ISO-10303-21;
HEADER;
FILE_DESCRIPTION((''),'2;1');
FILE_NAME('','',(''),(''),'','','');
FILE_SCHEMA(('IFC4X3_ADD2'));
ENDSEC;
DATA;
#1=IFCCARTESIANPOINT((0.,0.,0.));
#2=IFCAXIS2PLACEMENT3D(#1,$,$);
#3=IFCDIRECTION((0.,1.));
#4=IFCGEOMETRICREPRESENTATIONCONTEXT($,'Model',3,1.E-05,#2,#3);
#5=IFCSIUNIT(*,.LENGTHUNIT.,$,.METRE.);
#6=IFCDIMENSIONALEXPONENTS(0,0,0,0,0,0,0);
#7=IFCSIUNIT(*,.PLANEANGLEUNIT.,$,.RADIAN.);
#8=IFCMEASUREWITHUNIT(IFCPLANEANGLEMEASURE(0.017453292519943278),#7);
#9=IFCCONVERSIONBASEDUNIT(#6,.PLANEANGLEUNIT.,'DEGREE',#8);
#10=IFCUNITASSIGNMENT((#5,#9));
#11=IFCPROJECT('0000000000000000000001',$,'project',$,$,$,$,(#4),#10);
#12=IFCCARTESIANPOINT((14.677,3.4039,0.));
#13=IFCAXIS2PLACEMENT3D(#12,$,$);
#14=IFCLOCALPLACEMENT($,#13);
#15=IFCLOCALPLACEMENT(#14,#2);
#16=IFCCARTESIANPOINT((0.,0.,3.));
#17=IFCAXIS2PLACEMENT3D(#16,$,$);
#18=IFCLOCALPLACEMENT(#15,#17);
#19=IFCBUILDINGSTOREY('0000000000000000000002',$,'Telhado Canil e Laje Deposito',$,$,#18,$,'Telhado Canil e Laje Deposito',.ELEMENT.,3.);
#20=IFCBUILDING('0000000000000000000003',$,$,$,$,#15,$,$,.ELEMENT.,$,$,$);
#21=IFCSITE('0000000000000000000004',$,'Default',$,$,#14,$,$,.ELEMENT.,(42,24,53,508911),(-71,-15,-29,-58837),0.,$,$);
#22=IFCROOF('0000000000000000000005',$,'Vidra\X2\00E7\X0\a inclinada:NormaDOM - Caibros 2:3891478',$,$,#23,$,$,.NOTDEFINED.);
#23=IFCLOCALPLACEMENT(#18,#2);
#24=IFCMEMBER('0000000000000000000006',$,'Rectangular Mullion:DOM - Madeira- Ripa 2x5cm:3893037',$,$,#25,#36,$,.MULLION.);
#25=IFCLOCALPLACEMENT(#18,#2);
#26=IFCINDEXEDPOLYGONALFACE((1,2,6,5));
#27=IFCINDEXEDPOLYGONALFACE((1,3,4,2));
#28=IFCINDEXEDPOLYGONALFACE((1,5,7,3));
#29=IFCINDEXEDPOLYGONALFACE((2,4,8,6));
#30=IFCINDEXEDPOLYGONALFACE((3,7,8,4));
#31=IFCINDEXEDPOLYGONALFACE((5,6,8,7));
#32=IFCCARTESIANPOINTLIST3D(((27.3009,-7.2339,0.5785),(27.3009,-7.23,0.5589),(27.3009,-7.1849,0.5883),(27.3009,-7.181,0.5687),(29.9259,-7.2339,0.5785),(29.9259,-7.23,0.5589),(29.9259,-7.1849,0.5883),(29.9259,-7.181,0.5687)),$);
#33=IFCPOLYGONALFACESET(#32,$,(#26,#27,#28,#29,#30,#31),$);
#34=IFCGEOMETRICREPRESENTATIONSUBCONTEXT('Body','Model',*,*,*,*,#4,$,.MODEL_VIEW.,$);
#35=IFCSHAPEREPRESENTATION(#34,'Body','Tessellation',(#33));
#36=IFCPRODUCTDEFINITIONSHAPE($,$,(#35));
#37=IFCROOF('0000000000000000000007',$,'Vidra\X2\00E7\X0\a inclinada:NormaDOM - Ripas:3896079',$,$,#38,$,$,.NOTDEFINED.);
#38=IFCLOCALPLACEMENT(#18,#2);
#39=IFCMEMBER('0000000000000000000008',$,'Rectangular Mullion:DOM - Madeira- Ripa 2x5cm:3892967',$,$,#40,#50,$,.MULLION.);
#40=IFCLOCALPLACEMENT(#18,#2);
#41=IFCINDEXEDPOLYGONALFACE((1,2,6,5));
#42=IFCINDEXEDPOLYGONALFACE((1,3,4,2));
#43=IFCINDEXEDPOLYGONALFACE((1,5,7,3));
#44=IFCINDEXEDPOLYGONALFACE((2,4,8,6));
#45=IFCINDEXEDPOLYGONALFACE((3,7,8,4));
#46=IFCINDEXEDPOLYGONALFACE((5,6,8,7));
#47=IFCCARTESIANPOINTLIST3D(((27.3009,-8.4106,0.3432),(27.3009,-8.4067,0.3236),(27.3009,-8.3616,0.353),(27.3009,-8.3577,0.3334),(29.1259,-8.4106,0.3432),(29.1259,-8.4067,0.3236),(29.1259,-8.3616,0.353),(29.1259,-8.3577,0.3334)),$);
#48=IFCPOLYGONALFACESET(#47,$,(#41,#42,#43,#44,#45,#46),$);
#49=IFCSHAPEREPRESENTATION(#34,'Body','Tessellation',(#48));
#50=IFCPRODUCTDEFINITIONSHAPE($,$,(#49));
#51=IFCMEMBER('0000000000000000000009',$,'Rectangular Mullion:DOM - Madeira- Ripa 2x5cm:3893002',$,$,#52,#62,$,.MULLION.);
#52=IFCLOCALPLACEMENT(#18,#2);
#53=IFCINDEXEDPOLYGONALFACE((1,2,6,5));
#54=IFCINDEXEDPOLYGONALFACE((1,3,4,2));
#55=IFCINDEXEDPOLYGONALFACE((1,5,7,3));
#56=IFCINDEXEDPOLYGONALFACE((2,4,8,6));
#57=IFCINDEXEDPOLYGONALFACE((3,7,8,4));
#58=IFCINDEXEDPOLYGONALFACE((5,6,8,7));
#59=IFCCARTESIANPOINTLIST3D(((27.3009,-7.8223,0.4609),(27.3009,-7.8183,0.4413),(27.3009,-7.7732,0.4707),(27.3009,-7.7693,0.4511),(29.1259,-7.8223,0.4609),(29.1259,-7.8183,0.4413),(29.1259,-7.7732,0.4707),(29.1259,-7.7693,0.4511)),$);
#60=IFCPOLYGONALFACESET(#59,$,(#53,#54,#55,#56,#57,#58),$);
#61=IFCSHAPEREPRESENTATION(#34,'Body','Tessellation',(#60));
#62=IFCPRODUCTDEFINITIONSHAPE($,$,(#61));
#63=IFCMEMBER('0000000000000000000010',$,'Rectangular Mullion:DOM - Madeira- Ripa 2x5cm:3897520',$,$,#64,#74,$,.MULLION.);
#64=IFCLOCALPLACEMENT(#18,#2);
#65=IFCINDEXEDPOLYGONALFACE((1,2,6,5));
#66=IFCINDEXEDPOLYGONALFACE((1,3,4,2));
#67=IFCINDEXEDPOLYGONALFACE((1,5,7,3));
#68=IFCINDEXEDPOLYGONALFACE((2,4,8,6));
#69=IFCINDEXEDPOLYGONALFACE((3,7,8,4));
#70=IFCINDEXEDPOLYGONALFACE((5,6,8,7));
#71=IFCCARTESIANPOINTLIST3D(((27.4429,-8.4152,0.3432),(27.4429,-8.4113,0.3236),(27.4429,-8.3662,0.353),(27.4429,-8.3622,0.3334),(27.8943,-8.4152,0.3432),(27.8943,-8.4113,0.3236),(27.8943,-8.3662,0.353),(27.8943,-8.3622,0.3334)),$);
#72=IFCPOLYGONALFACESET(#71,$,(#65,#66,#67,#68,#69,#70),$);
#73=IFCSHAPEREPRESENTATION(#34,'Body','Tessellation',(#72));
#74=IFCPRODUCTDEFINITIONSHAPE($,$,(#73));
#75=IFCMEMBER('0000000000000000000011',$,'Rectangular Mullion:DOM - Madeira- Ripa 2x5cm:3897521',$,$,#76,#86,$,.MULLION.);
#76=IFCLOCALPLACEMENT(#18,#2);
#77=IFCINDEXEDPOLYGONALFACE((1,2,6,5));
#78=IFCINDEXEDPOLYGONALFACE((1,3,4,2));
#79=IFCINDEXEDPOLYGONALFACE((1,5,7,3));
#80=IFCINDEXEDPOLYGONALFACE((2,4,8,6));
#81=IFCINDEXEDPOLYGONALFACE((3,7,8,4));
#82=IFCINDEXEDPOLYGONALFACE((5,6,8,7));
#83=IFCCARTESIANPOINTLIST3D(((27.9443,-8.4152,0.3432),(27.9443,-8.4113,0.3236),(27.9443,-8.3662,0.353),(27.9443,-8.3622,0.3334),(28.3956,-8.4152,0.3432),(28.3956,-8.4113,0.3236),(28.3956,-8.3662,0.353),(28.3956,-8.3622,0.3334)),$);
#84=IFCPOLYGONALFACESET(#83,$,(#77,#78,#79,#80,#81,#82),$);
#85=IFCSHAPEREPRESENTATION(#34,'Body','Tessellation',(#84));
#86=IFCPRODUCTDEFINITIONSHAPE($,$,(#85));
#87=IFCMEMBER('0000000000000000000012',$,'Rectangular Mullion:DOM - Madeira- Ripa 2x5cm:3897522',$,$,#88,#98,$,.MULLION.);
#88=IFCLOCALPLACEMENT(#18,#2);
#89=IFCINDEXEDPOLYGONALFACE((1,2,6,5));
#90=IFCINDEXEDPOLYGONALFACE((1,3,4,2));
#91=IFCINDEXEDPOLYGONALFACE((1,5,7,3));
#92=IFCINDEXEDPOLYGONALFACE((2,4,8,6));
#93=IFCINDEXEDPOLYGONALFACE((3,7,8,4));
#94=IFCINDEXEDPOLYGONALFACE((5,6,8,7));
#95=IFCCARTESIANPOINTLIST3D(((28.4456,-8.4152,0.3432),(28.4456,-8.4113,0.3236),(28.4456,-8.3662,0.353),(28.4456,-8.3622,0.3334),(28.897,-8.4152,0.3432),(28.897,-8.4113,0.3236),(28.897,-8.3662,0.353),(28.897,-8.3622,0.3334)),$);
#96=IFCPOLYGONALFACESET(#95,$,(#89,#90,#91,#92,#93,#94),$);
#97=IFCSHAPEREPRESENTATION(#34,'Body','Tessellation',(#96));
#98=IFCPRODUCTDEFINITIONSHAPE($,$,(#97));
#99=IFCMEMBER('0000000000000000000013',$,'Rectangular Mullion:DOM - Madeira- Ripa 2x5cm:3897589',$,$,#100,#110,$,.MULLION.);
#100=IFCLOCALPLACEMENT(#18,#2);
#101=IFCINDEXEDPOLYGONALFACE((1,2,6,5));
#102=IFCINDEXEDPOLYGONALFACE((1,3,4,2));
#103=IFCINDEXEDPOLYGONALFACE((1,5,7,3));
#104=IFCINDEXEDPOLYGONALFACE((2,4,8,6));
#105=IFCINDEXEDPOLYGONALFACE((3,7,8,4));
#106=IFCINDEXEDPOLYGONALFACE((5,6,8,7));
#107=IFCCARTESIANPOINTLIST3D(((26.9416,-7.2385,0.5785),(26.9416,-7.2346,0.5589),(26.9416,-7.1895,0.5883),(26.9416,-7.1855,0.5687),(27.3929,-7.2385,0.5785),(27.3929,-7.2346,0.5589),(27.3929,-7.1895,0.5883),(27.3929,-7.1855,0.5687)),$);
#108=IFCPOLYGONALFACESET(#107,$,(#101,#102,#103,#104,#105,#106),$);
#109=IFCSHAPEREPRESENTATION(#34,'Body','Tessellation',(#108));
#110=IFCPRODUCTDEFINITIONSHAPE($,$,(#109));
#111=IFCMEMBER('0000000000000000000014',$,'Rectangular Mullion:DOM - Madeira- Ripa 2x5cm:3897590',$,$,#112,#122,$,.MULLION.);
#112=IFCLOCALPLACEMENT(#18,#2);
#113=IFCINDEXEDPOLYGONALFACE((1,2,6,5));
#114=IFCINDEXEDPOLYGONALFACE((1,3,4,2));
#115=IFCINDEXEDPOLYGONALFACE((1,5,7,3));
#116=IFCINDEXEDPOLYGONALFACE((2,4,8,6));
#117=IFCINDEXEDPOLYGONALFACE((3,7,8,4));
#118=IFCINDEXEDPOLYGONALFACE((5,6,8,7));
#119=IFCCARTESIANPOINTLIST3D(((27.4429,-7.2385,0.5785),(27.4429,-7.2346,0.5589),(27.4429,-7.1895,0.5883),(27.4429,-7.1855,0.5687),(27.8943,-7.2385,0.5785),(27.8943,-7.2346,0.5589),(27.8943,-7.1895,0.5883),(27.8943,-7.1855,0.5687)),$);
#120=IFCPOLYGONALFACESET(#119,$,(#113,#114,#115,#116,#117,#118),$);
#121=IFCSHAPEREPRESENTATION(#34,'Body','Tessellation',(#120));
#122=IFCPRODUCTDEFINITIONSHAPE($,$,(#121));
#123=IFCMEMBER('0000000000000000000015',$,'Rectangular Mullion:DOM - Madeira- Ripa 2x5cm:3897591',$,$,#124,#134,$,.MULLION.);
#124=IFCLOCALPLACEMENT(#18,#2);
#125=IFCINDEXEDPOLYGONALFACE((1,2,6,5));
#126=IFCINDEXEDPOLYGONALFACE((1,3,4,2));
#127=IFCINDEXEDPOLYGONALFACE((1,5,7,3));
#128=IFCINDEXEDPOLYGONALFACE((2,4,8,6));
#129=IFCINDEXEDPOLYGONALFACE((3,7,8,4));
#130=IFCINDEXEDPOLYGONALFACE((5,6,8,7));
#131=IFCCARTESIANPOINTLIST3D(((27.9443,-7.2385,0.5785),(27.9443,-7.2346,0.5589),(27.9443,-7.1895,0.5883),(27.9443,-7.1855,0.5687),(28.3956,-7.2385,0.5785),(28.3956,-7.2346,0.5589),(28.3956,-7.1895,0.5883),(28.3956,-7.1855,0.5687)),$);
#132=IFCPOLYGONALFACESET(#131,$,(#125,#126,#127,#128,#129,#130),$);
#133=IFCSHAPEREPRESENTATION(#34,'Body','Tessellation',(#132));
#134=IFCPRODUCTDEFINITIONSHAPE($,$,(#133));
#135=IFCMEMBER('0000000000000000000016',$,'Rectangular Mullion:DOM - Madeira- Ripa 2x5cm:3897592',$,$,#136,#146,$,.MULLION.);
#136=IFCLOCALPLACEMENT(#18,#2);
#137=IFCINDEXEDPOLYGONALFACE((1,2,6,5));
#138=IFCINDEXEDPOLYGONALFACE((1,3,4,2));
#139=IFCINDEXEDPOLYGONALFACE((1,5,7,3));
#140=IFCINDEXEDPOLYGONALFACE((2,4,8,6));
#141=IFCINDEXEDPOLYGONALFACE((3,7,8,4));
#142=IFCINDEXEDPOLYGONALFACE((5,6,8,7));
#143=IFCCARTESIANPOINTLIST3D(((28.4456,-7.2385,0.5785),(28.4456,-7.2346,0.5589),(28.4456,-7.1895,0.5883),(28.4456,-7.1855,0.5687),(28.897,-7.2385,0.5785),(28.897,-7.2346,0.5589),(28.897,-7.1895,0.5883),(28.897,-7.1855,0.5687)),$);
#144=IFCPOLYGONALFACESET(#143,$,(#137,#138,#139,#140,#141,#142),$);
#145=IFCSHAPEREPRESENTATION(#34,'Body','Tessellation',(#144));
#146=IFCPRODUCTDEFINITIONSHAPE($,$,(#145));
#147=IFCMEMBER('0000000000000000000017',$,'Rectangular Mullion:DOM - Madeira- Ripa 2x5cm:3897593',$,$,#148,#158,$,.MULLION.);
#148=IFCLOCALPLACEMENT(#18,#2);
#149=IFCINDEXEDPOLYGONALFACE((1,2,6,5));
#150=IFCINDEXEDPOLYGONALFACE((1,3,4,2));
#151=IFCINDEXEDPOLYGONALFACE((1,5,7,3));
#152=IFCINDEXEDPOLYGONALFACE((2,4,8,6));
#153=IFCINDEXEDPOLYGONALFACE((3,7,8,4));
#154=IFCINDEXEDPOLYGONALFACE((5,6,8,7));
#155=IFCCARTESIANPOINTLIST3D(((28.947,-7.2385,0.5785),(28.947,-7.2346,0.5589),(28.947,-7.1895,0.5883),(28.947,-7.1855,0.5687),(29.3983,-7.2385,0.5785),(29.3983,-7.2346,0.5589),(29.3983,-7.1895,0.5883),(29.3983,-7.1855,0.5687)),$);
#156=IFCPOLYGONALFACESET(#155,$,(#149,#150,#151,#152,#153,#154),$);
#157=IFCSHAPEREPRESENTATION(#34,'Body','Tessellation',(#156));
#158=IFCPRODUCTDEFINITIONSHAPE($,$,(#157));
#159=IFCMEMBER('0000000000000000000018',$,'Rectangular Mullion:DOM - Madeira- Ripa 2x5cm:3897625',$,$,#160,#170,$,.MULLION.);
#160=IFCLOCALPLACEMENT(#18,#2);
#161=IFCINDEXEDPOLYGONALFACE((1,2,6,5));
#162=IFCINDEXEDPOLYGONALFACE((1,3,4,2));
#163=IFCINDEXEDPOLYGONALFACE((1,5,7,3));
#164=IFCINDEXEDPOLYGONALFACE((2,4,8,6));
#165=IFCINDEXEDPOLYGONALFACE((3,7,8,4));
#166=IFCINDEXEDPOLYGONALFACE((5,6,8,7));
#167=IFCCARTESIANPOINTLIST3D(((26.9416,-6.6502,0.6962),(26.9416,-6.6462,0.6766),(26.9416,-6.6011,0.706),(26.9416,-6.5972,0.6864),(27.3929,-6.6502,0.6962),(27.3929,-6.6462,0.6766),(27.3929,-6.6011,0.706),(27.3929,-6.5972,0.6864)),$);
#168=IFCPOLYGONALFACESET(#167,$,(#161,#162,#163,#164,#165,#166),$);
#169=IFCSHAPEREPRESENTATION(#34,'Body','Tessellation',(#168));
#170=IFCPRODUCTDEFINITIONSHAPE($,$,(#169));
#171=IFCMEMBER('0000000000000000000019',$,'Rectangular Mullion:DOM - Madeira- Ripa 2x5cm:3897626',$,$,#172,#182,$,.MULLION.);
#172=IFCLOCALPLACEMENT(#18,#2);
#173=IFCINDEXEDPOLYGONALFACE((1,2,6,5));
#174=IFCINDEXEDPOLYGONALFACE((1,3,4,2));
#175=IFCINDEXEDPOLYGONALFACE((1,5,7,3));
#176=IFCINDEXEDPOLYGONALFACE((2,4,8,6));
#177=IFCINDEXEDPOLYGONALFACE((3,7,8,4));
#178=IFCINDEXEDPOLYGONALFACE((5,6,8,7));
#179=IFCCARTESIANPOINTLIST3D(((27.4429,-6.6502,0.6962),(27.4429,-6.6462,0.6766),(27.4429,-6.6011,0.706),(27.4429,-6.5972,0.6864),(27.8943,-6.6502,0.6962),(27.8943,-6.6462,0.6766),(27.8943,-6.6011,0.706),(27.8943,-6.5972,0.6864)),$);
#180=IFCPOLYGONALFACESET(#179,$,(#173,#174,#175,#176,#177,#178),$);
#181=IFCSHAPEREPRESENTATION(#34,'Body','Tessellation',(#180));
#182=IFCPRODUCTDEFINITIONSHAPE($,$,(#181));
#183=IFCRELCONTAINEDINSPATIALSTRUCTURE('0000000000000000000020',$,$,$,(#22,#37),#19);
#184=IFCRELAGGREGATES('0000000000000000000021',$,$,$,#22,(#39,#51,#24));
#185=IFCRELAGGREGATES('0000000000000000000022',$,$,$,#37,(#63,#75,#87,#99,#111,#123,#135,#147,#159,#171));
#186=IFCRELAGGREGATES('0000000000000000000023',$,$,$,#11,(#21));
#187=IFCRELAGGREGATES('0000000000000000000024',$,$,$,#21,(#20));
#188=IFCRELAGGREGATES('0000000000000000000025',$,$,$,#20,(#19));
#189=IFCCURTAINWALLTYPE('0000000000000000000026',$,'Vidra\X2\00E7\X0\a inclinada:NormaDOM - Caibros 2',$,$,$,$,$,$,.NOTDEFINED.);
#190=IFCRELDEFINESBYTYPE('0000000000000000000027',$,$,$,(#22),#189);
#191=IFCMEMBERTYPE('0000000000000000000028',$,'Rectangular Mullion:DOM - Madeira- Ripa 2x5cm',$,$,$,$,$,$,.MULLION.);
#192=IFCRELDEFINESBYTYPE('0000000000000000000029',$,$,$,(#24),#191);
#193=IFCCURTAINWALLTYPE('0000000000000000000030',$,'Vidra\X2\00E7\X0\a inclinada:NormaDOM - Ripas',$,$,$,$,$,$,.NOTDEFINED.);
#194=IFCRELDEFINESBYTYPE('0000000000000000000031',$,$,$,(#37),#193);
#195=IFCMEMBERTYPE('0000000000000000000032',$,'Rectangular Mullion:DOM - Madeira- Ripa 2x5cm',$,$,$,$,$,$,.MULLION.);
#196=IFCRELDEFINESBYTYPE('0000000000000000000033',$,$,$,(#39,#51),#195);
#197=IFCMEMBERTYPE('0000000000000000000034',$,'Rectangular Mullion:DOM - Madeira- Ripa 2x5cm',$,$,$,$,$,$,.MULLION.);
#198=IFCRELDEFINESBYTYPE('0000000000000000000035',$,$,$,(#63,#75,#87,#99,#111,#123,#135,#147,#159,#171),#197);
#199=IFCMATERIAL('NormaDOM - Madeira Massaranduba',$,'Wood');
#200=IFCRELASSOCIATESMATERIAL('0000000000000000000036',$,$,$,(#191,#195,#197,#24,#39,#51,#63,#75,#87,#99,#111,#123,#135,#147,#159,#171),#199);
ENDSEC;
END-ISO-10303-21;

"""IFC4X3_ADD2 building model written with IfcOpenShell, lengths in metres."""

from ifc_helpers import new_model, entity, si_unit, converted_unit, direction, frame, origin, origin_2d_with_axis, place, context, subcontext, project, spatial, rectangle, extrude, source, transform, mapped, material, material_profile, profile_set, profile_usage, type_object, type_shapes, element, aggregate, save


model = new_model("IFC4X3_ADD2")

# Units and contexts
model_context = context("Model", 3, precision=1e-05, world=origin(), true_north=direction((0.0, 1.0)))
body_context = subcontext(model_context, "Body", "Model", "MODEL_VIEW")
ifc_project = project(units=[si_unit("LENGTHUNIT", "METRE"), converted_unit("PLANEANGLEUNIT", "DEGREE", entity("IfcPlaneAngleMeasure", 0.017453292519943278), si_unit("PLANEANGLEUNIT", "RADIAN"), dimensions=[0, 0, 0, 0, 0, 0, 0])], contexts=[model_context])

# Site, building, storey
site_placement = place(None, frame((14.677, 3.4039, 0.0)))
site = spatial("IfcSite", under=ifc_project, at=site_placement, Name="Default", CompositionType="ELEMENT", RefLatitude=(42, 24, 53, 508911), RefLongitude=(-71, -15, -29, -58837), RefElevation=0.0)
building_placement = place(site_placement, origin())
building = spatial("IfcBuilding", under=site, at=building_placement, CompositionType="ELEMENT")
storey_placement = place(building_placement, frame((0.0, 0.0, 3.0)))
storey = spatial("IfcBuildingStorey", under=building, at=storey_placement, Name="Telhado Canil e Laje Deposito", LongName="Telhado Canil e Laje Deposito", CompositionType="ELEMENT", Elevation=3.0)

# Roofs, member
curtain_wall_type_1 = type_object("IfcCurtainWallType", Name="Vidraça inclinada:NormaDOM - Caibros 2", PredefinedType="NOTDEFINED")
roof_1_placement = place(storey_placement, frame((0.0, 0.0, -3.0)))
roof_1 = element("IfcRoof", 1, at=roof_1_placement, inside=storey, type_object=curtain_wall_type_1, Name="Vidraça inclinada:NormaDOM - Caibros 2:3891478", PredefinedType="NOTDEFINED")
ifc_material = material(Name="NormaDOM - Madeira Massaranduba", Category="Wood")
ifc_material_profile_1 = material_profile(ifc_material, rectangle(XDim=0.05, YDim=0.02, at=origin_2d_with_axis()), Name="DOM - Madeira- Ripa 2x5cm")
ifc_profile_set_1 = profile_set([ifc_material_profile_1], Name="DOM - Madeira- Ripa 2x5cm")
ifc_profile_usage_1 = profile_usage(ifc_profile_set_1)
member_type_1 = type_object("IfcMemberType", Name="Rectangular Mullion:DOM - Madeira- Ripa 2x5cm", PredefinedType="MULLION", material=ifc_profile_set_1)
shared_shape_1 = source(origin(), body_context, "Body", "SweptSolid", [
    extrude(rectangle(XDim=0.05, YDim=0.02, at=origin_2d_with_axis()), frame((0.025, 0.01, -2.625), z_axis=(0.0, 0.0, 1.0), x_axis=(-1.0, 0.0, 0.0)), (0.0, 0.0, 1.0), 2.625),
])
type_shapes(member_type_1, [shared_shape_1])
member_1_placement = place(roof_1_placement, frame((27.3009, -7.2339, 3.5785), z_axis=(-1.0, 0.0, 0.0), x_axis=(0.0, 0.980581, 0.196116)))
member_1 = element("IfcMember", 2, at=member_1_placement, type_object=member_type_1, material=ifc_profile_usage_1, Name="Rectangular Mullion:DOM - Madeira- Ripa 2x5cm:3893037", PredefinedType="MULLION", context=body_context, shape_type="MappedRepresentation", body=[
    mapped(shared_shape_1, transform((0.0, 0.0, 0.0), scale=1.0)),
])
curtain_wall_type_2 = type_object("IfcCurtainWallType", Name="Vidraça inclinada:NormaDOM - Ripas", PredefinedType="NOTDEFINED")
roof_2_placement = place(storey_placement, frame((0.0, 0.0, -3.0)))
roof_2 = element("IfcRoof", 3, at=roof_2_placement, inside=storey, type_object=curtain_wall_type_2, Name="Vidraça inclinada:NormaDOM - Ripas:3896079", PredefinedType="NOTDEFINED")

# Members
member_type_2 = type_object("IfcMemberType", Name="Rectangular Mullion:DOM - Madeira- Ripa 2x5cm", PredefinedType="MULLION", material=ifc_profile_set_1)
shared_shape_2 = source(origin(), body_context, "Body", "SweptSolid", [
    extrude(rectangle(XDim=0.05, YDim=0.02, at=origin_2d_with_axis()), frame((0.025, 0.01, -1.825), z_axis=(0.0, 0.0, 1.0), x_axis=(-1.0, 0.0, 0.0)), (0.0, 0.0, 1.0), 1.825),
])
type_shapes(member_type_2, [shared_shape_2])
member_2_placement = place(roof_1_placement, frame((27.3009, -8.4106, 3.3432), z_axis=(-1.0, 0.0, 0.0), x_axis=(0.0, 0.980581, 0.196116)))
member_2 = element("IfcMember", 4, at=member_2_placement, type_object=member_type_2, material=ifc_profile_usage_1, Name="Rectangular Mullion:DOM - Madeira- Ripa 2x5cm:3892967", PredefinedType="MULLION", context=body_context, shape_type="MappedRepresentation", body=[
    mapped(shared_shape_2, transform((0.0, 0.0, 0.0), scale=1.0)),
])
member_3_placement = place(roof_1_placement, frame((27.3009, -7.8223, 3.4609), z_axis=(-1.0, 0.0, 0.0), x_axis=(0.0, 0.980581, 0.196116)))
member_3 = element("IfcMember", 5, at=member_3_placement, type_object=member_type_2, material=ifc_profile_usage_1, Name="Rectangular Mullion:DOM - Madeira- Ripa 2x5cm:3893002", PredefinedType="MULLION", context=body_context, shape_type="MappedRepresentation", body=[
    mapped(shared_shape_2, transform((0.0, 0.0, 0.0), scale=1.0)),
])
aggregate(roof_1, [member_2, member_3, member_1])
member_type_3 = type_object("IfcMemberType", Name="Rectangular Mullion:DOM - Madeira- Ripa 2x5cm", PredefinedType="MULLION", material=ifc_profile_set_1)
shared_shape_3 = source(origin(), body_context, "Body", "SweptSolid", [
    extrude(rectangle(XDim=0.05, YDim=0.02, at=origin_2d_with_axis()), frame((0.025, 0.01, -0.4514), z_axis=(0.0, 0.0, 1.0), x_axis=(-1.0, 0.0, 0.0)), (0.0, 0.0, 1.0), 0.4514),
])
type_shapes(member_type_3, [shared_shape_3])
member_4_placement = place(roof_2_placement, frame((27.4429, -8.4152, 3.3432), z_axis=(-1.0, 0.0, 0.0), x_axis=(0.0, 0.980581, 0.196116)))
member_4 = element("IfcMember", 6, at=member_4_placement, type_object=member_type_3, material=ifc_profile_usage_1, Name="Rectangular Mullion:DOM - Madeira- Ripa 2x5cm:3897520", PredefinedType="MULLION", context=body_context, shape_type="MappedRepresentation", body=[
    mapped(shared_shape_3, transform((0.0, 0.0, 0.0), scale=1.0)),
])
member_5_placement = place(roof_2_placement, frame((27.9443, -8.4152, 3.3432), z_axis=(-1.0, 0.0, 0.0), x_axis=(0.0, 0.980581, 0.196116)))
member_5 = element("IfcMember", 7, at=member_5_placement, type_object=member_type_3, material=ifc_profile_usage_1, Name="Rectangular Mullion:DOM - Madeira- Ripa 2x5cm:3897521", PredefinedType="MULLION", context=body_context, shape_type="MappedRepresentation", body=[
    mapped(shared_shape_3, transform((0.0, 0.0, 0.0), scale=1.0)),
])
member_6_placement = place(roof_2_placement, frame((28.4456, -8.4152, 3.3432), z_axis=(-1.0, 0.0, 0.0), x_axis=(0.0, 0.980581, 0.196116)))
member_6 = element("IfcMember", 8, at=member_6_placement, type_object=member_type_3, material=ifc_profile_usage_1, Name="Rectangular Mullion:DOM - Madeira- Ripa 2x5cm:3897522", PredefinedType="MULLION", context=body_context, shape_type="MappedRepresentation", body=[
    mapped(shared_shape_3, transform((0.0, 0.0, 0.0), scale=1.0)),
])
member_7_placement = place(roof_2_placement, frame((26.9416, -7.2385, 3.5785), z_axis=(-1.0, 0.0, 0.0), x_axis=(0.0, 0.980581, 0.196116)))
member_7 = element("IfcMember", 9, at=member_7_placement, type_object=member_type_3, material=ifc_profile_usage_1, Name="Rectangular Mullion:DOM - Madeira- Ripa 2x5cm:3897589", PredefinedType="MULLION", context=body_context, shape_type="MappedRepresentation", body=[
    mapped(shared_shape_3, transform((0.0, 0.0, 0.0), scale=1.0)),
])
member_8_placement = place(roof_2_placement, frame((27.4429, -7.2385, 3.5785), z_axis=(-1.0, 0.0, 0.0), x_axis=(0.0, 0.980581, 0.196116)))
member_8 = element("IfcMember", 10, at=member_8_placement, type_object=member_type_3, material=ifc_profile_usage_1, Name="Rectangular Mullion:DOM - Madeira- Ripa 2x5cm:3897590", PredefinedType="MULLION", context=body_context, shape_type="MappedRepresentation", body=[
    mapped(shared_shape_3, transform((0.0, 0.0, 0.0), scale=1.0)),
])
member_9_placement = place(roof_2_placement, frame((27.9443, -7.2385, 3.5785), z_axis=(-1.0, 0.0, 0.0), x_axis=(0.0, 0.980581, 0.196116)))
member_9 = element("IfcMember", 11, at=member_9_placement, type_object=member_type_3, material=ifc_profile_usage_1, Name="Rectangular Mullion:DOM - Madeira- Ripa 2x5cm:3897591", PredefinedType="MULLION", context=body_context, shape_type="MappedRepresentation", body=[
    mapped(shared_shape_3, transform((0.0, 0.0, 0.0), scale=1.0)),
])
member_10_placement = place(roof_2_placement, frame((28.4456, -7.2385, 3.5785), z_axis=(-1.0, 0.0, 0.0), x_axis=(0.0, 0.980581, 0.196116)))
member_10 = element("IfcMember", 12, at=member_10_placement, type_object=member_type_3, material=ifc_profile_usage_1, Name="Rectangular Mullion:DOM - Madeira- Ripa 2x5cm:3897592", PredefinedType="MULLION", context=body_context, shape_type="MappedRepresentation", body=[
    mapped(shared_shape_3, transform((0.0, 0.0, 0.0), scale=1.0)),
])
member_11_placement = place(roof_2_placement, frame((28.947, -7.2385, 3.5785), z_axis=(-1.0, 0.0, 0.0), x_axis=(0.0, 0.980581, 0.196116)))
member_11 = element("IfcMember", 13, at=member_11_placement, type_object=member_type_3, material=ifc_profile_usage_1, Name="Rectangular Mullion:DOM - Madeira- Ripa 2x5cm:3897593", PredefinedType="MULLION", context=body_context, shape_type="MappedRepresentation", body=[
    mapped(shared_shape_3, transform((0.0, 0.0, 0.0), scale=1.0)),
])
member_12_placement = place(roof_2_placement, frame((26.9416, -6.6502, 3.6962), z_axis=(-1.0, 0.0, 0.0), x_axis=(0.0, 0.980581, 0.196116)))
member_12 = element("IfcMember", 14, at=member_12_placement, type_object=member_type_3, material=ifc_profile_usage_1, Name="Rectangular Mullion:DOM - Madeira- Ripa 2x5cm:3897625", PredefinedType="MULLION", context=body_context, shape_type="MappedRepresentation", body=[
    mapped(shared_shape_3, transform((0.0, 0.0, 0.0), scale=1.0)),
])
member_13_placement = place(roof_2_placement, frame((27.4429, -6.6502, 3.6962), z_axis=(-1.0, 0.0, 0.0), x_axis=(0.0, 0.980581, 0.196116)))
member_13 = element("IfcMember", 15, at=member_13_placement, type_object=member_type_3, material=ifc_profile_usage_1, Name="Rectangular Mullion:DOM - Madeira- Ripa 2x5cm:3897626", PredefinedType="MULLION", context=body_context, shape_type="MappedRepresentation", body=[
    mapped(shared_shape_3, transform((0.0, 0.0, 0.0), scale=1.0)),
])
aggregate(roof_2, [member_4, member_5, member_6, member_7, member_8, member_9, member_10, member_11, member_12, member_13])

save(model, "model.ifc")
